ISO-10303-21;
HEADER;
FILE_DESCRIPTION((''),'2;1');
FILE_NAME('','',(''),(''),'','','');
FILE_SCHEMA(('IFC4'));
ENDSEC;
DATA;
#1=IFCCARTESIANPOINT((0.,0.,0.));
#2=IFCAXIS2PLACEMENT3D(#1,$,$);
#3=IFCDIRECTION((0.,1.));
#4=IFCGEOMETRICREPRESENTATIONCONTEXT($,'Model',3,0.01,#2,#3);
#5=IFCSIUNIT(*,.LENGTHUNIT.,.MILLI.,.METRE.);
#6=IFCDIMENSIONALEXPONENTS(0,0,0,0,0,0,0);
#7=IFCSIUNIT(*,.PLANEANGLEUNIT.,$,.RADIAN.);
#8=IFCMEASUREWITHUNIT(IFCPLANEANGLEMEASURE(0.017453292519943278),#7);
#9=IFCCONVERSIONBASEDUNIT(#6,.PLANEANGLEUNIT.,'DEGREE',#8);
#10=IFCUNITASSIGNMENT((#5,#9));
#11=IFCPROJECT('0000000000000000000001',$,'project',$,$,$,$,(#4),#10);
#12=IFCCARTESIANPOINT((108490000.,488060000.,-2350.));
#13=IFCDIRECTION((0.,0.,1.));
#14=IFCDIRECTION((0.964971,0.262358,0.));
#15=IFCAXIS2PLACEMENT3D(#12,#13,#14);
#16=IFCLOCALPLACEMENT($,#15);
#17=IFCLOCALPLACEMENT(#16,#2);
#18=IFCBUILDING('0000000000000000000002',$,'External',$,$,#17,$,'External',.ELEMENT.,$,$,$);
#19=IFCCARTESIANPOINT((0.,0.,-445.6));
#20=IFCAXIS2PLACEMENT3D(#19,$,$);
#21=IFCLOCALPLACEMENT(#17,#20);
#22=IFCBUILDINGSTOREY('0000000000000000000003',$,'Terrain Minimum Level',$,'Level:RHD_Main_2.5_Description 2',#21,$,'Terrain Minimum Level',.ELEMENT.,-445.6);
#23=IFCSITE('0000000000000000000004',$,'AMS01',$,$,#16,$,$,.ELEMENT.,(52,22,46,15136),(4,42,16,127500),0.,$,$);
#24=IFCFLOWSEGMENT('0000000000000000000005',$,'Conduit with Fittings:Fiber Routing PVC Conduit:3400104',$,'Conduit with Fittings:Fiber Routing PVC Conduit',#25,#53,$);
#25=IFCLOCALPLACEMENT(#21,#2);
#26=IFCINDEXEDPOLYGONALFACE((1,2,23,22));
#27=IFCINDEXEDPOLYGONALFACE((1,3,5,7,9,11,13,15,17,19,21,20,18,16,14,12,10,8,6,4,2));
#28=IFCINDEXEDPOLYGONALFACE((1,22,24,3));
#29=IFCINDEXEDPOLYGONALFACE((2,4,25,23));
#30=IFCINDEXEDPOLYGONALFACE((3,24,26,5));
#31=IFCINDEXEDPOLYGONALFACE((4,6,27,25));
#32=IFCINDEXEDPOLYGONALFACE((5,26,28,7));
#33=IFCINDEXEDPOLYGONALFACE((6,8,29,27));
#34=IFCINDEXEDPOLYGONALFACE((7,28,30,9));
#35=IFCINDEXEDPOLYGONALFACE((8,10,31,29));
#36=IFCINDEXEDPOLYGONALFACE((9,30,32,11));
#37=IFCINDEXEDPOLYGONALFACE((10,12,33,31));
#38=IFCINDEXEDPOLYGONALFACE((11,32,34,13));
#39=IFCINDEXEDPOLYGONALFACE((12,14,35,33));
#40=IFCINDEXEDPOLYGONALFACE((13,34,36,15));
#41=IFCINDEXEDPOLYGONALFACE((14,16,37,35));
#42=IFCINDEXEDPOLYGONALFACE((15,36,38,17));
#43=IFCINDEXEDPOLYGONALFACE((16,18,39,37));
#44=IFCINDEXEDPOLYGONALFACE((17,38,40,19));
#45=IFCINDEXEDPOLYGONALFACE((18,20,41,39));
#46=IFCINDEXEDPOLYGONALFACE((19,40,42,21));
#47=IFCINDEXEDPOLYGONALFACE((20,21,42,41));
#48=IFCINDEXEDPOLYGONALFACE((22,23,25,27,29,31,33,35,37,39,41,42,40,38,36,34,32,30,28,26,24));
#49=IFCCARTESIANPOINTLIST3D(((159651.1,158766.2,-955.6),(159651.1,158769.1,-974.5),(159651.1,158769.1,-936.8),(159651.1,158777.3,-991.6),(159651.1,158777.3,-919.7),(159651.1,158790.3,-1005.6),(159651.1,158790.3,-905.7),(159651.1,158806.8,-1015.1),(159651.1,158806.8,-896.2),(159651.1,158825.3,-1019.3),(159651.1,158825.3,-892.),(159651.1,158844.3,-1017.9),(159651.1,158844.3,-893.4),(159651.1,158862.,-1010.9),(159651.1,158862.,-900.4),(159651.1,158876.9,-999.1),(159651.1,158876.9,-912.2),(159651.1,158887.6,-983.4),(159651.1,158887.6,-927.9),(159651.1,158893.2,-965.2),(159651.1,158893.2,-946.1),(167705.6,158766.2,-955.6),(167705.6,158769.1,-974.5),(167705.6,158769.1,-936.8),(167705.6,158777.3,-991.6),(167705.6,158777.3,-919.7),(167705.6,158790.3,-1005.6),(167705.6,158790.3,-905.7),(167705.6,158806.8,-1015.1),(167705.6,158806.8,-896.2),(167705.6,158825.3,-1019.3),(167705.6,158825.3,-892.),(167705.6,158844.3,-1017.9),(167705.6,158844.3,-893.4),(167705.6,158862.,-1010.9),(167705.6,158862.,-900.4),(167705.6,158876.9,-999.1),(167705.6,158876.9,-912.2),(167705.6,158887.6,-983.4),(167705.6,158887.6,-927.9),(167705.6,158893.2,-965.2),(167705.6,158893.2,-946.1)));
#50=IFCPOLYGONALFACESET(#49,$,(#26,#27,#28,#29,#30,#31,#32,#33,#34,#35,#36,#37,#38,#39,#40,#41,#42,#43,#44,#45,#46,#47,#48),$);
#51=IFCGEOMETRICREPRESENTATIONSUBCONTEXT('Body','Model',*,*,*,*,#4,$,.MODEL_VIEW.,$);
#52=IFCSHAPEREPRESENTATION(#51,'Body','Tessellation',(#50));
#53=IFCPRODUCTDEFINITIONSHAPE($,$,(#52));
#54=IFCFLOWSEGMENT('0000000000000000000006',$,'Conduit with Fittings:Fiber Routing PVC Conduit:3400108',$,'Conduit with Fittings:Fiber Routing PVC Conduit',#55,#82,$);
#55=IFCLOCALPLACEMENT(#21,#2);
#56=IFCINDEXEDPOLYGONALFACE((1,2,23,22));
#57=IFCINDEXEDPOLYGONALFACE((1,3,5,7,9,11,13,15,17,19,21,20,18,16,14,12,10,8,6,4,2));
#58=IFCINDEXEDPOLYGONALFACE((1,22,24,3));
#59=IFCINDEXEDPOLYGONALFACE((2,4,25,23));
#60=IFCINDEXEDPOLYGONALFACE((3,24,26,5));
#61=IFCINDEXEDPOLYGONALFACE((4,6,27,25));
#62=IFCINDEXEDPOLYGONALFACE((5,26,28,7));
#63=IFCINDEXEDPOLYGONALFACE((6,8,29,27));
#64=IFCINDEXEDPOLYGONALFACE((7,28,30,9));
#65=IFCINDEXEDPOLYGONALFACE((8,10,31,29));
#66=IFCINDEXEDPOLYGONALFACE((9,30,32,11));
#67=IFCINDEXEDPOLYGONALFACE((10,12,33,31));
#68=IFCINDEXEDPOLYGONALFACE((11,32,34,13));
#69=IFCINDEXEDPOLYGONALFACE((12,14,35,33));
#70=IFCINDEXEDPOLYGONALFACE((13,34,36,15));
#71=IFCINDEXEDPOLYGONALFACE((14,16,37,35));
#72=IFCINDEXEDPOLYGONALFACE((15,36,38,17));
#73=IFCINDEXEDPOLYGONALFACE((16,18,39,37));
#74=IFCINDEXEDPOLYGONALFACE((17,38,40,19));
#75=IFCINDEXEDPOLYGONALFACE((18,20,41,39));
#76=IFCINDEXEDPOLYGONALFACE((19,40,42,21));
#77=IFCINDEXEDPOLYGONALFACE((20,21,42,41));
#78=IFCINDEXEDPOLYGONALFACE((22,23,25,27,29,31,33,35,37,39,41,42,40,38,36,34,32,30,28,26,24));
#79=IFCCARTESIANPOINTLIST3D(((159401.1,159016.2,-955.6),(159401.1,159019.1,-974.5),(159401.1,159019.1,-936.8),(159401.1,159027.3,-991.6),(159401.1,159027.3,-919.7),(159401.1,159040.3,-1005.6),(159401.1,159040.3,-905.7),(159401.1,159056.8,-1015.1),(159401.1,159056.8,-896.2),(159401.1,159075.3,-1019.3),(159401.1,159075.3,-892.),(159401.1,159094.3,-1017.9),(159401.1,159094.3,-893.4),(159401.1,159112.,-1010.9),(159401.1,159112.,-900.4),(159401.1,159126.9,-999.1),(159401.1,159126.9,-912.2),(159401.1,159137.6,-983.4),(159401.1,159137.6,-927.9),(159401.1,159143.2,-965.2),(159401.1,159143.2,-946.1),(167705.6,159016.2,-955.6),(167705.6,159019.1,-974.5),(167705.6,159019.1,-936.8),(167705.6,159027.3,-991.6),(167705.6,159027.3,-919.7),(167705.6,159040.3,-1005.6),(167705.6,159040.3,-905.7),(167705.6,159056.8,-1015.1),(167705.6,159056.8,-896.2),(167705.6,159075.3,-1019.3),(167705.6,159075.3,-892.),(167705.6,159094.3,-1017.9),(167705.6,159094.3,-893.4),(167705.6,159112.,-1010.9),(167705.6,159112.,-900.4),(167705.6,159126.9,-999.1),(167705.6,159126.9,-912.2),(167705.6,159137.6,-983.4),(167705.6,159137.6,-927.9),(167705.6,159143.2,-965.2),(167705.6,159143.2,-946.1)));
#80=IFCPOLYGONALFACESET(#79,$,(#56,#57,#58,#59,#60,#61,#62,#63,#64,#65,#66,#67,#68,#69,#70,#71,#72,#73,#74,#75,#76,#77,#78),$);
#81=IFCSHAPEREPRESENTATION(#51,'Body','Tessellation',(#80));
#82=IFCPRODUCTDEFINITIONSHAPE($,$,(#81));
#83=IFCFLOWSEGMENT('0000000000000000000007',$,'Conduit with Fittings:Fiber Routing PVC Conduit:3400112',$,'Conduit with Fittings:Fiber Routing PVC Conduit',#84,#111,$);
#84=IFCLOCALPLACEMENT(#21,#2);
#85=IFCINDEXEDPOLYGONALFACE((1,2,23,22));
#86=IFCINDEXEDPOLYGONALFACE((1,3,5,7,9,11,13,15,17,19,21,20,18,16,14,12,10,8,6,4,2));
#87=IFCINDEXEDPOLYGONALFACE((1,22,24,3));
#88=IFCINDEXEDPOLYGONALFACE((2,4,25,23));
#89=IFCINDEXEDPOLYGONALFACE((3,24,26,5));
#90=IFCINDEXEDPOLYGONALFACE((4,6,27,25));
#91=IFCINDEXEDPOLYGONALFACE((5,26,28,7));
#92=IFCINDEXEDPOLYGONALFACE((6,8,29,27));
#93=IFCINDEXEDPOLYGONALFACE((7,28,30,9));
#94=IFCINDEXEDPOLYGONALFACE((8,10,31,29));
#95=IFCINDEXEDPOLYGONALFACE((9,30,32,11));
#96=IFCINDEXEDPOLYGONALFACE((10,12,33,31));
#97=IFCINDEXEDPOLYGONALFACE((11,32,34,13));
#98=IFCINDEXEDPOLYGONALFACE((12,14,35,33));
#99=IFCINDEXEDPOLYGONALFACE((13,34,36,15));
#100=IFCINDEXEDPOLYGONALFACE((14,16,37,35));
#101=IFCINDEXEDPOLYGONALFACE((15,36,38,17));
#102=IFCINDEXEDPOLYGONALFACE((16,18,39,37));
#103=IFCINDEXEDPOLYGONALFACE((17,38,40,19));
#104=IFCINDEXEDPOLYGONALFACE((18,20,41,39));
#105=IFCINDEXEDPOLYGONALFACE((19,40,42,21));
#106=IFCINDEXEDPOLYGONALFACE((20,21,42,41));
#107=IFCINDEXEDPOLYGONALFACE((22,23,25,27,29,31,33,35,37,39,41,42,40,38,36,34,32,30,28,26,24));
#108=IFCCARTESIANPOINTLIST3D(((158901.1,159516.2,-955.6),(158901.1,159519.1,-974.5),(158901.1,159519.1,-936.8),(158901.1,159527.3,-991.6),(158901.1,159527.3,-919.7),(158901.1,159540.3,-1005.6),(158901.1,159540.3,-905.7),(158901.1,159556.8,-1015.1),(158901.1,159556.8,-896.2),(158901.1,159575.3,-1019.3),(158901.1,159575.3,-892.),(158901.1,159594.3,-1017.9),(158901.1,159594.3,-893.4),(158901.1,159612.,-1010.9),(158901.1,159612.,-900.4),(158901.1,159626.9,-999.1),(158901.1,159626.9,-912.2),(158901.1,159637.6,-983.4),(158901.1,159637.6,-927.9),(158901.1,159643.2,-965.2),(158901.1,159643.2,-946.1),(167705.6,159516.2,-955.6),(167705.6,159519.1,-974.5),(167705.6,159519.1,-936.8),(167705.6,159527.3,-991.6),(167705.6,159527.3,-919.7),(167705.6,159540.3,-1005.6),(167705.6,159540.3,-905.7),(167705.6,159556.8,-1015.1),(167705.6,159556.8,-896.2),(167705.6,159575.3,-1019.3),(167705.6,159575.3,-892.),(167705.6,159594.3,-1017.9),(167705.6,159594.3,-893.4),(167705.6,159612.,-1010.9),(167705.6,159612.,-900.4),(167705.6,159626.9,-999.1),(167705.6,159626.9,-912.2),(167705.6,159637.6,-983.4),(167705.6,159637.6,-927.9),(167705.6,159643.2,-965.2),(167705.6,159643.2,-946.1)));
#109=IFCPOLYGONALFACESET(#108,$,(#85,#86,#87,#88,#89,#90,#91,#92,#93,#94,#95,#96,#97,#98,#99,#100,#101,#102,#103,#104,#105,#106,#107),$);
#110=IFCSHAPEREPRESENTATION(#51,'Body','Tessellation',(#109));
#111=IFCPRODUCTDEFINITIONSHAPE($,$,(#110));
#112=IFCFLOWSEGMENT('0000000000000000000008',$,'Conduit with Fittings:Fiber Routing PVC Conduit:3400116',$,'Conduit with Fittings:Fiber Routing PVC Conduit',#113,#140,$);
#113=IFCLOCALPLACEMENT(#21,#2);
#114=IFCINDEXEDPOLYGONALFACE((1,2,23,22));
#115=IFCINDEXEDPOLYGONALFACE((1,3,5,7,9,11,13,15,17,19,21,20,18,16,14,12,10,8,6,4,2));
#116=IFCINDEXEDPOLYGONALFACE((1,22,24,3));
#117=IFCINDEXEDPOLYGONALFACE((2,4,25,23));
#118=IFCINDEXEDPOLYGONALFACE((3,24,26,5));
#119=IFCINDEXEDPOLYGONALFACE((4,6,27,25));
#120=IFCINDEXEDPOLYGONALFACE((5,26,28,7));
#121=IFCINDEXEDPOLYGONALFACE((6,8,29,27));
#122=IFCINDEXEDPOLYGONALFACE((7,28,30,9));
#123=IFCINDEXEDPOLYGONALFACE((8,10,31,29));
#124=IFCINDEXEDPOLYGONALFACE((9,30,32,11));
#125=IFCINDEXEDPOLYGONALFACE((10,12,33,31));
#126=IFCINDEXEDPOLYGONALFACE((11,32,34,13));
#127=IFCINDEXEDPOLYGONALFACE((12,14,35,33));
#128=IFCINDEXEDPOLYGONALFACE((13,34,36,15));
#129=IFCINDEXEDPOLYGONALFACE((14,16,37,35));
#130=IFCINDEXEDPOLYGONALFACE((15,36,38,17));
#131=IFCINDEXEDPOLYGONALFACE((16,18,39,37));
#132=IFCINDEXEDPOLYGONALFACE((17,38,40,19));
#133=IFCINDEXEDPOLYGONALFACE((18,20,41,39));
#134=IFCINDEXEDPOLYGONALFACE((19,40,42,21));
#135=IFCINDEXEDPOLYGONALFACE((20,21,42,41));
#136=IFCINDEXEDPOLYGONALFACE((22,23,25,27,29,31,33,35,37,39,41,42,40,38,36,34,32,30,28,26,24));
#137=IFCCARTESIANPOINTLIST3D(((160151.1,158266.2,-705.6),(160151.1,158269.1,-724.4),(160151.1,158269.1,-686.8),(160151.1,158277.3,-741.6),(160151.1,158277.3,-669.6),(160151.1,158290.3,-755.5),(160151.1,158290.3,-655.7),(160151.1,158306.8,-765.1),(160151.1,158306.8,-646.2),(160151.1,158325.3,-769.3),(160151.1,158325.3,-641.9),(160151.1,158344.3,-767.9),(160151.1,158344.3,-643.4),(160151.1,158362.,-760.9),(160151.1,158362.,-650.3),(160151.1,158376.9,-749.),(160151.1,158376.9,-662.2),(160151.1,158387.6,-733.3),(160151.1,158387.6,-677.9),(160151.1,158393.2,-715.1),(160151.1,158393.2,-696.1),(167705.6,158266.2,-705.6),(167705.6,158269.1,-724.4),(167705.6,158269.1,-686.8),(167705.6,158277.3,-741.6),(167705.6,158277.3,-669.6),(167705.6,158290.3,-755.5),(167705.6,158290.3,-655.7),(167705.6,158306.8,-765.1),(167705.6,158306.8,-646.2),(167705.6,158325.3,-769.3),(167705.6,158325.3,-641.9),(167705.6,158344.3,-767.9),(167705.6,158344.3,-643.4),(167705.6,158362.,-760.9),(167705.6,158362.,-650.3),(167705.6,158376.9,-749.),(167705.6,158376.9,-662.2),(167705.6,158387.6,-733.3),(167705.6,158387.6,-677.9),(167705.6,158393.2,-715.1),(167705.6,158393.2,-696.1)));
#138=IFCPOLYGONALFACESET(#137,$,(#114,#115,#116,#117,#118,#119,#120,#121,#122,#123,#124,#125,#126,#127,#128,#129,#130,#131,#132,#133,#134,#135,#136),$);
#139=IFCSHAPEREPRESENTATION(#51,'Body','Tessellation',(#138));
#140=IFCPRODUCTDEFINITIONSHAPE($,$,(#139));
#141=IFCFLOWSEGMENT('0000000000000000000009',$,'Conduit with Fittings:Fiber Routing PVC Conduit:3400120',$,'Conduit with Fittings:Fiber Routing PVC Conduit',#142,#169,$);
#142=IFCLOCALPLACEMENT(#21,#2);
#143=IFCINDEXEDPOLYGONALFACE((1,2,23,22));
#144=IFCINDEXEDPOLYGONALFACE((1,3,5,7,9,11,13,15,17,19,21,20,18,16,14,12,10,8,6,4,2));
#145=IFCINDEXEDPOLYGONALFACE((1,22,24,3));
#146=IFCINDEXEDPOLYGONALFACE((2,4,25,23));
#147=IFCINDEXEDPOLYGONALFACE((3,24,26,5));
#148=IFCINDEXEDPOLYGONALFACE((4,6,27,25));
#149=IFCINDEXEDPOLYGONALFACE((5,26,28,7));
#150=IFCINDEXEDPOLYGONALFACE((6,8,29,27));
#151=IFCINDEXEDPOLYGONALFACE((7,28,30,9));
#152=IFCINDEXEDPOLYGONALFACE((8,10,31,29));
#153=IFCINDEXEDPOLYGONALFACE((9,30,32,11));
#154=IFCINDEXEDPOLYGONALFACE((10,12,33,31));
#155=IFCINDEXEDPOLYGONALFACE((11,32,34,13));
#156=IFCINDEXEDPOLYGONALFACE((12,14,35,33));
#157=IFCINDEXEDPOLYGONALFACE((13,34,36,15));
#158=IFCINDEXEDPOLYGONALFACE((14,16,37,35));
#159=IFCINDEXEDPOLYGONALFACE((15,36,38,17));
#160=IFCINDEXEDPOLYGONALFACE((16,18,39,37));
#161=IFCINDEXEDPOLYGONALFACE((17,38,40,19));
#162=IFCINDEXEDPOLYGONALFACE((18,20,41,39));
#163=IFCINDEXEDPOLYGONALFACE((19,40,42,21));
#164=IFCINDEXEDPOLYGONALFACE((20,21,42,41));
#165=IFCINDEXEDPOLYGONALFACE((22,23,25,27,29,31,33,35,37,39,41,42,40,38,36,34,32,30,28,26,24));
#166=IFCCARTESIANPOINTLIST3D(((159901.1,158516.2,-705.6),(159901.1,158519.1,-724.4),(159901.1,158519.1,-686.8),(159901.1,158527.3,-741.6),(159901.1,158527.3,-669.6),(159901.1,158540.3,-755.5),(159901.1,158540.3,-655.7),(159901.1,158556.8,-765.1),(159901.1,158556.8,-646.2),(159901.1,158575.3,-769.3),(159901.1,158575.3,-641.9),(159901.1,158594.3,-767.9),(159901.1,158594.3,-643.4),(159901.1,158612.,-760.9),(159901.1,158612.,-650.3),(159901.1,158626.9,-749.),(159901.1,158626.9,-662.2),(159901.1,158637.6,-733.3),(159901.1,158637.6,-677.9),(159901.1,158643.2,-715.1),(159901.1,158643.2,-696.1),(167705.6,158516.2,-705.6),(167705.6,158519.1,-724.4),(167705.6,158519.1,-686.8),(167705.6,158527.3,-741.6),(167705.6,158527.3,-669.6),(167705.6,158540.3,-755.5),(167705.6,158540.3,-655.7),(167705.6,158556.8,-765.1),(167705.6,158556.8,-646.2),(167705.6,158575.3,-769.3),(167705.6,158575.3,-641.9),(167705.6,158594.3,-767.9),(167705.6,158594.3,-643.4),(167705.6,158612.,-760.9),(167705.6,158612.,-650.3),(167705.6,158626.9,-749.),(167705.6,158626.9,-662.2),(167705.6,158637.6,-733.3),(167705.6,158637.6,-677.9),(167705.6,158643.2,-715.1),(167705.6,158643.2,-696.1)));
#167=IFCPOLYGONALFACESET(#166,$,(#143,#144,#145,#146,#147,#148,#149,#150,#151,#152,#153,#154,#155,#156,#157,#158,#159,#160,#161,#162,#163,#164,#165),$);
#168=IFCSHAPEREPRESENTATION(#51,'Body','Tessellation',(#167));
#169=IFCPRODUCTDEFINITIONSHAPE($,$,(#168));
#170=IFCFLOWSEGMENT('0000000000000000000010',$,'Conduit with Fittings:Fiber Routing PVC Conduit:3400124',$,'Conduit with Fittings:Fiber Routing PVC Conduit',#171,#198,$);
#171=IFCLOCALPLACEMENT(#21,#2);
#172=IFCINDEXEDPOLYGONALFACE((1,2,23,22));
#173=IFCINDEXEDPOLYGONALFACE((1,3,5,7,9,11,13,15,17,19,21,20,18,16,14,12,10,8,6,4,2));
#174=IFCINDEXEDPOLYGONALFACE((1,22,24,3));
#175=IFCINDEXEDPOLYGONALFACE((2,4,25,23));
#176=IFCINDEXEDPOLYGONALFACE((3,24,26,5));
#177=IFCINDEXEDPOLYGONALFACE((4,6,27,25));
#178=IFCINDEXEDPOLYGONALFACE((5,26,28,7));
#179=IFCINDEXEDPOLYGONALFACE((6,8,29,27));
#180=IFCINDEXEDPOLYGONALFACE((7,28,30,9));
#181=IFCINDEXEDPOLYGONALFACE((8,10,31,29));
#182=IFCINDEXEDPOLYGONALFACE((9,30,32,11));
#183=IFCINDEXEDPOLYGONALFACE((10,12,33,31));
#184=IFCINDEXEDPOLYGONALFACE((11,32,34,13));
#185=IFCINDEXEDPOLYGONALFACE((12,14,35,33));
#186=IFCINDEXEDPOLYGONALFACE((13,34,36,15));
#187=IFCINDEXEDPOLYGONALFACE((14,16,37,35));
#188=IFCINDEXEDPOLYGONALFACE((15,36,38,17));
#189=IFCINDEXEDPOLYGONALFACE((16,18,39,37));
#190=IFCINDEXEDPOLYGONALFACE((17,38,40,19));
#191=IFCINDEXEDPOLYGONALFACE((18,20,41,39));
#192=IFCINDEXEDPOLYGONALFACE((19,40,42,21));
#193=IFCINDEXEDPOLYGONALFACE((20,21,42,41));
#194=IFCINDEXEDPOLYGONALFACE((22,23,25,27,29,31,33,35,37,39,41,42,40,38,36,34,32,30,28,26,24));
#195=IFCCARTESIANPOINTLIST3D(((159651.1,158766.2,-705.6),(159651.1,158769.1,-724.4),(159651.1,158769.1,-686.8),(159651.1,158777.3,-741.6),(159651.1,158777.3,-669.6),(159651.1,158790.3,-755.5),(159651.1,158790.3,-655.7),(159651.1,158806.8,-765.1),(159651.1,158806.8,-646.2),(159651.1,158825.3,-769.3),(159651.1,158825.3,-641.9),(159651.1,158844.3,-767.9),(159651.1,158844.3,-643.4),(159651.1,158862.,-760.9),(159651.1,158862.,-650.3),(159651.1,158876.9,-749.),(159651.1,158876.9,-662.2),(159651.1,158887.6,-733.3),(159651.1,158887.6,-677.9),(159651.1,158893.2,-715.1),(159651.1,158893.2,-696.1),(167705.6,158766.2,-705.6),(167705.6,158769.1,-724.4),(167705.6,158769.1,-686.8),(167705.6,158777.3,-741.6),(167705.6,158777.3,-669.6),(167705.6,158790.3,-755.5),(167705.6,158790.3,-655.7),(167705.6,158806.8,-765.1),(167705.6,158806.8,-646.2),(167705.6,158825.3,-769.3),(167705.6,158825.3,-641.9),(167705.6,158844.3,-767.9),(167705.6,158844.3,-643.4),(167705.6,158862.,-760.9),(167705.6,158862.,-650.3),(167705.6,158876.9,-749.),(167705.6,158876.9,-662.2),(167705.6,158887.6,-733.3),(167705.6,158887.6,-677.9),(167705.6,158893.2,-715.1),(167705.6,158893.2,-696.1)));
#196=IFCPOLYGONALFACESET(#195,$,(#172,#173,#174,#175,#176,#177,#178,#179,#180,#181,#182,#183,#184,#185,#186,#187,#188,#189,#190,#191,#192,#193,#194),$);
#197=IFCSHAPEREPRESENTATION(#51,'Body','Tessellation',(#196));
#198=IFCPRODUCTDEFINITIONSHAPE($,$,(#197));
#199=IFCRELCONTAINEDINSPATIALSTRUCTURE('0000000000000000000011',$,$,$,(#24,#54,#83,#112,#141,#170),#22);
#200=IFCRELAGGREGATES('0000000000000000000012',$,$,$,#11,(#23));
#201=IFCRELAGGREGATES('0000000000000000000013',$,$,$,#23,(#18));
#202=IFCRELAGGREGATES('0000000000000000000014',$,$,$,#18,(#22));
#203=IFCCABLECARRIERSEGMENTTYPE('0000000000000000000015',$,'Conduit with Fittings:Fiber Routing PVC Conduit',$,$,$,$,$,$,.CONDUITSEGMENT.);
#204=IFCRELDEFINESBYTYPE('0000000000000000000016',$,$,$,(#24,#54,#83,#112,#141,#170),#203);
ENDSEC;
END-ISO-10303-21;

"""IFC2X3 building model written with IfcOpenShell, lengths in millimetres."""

from ifc_helpers import new_model, entity, si_unit, converted_unit, direction, frame, frame_2d, origin, origin_2d_with_axis, place, context, subcontext, project, spatial, circle, extrude, type_object, element, save


model = new_model("IFC2X3")

# Units and contexts
model_context = context("Model", 3, precision=0.01, world=origin(), true_north=direction((0.0, 1.0)))
body_context = subcontext(model_context, "Body", "Model", "MODEL_VIEW")
ifc_project = project(units=[si_unit("LENGTHUNIT", "METRE", prefix="MILLI"), converted_unit("PLANEANGLEUNIT", "DEGREE", entity("IfcPlaneAngleMeasure", 0.017453292519943278), si_unit("PLANEANGLEUNIT", "RADIAN"), dimensions=[0, 0, 0, 0, 0, 0, 0])], contexts=[model_context])

# Site, building, storey
site_placement = place(None, frame((108490000.0, 488060000.0, -2350.0), z_axis=(0.0, 0.0, 1.0), x_axis=(0.964971, 0.262358, 0.0)))
site = spatial("IfcSite", under=ifc_project, at=site_placement, Name="AMS01", CompositionType="ELEMENT", RefLatitude=(52, 22, 46, 15136), RefLongitude=(4, 42, 16, 127500), RefElevation=0.0)
building_placement = place(site_placement, origin())
building = spatial("IfcBuilding", under=site, at=building_placement, Name="External", LongName="External", CompositionType="ELEMENT")
storey_placement = place(building_placement, frame((0.0, 0.0, -445.6)))
storey = spatial("IfcBuildingStorey", under=building, at=storey_placement, Name="Terrain Minimum Level", ObjectType="Level:RHD_Main_2.5_Description 2", LongName="Terrain Minimum Level", CompositionType="ELEMENT", Elevation=-445.6)

# Flow segments
cable_carrier_segment_type = type_object("IfcCableCarrierSegmentType", Name="Conduit with Fittings:Fiber Routing PVC Conduit", PredefinedType="CONDUITSEGMENT")
flow_segment_1_placement = place(storey_placement, origin())
element("IfcFlowSegment", 1, at=flow_segment_1_placement, inside=storey, type_object=cable_carrier_segment_type, Name="Conduit with Fittings:Fiber Routing PVC Conduit:3400104", ObjectType="Conduit with Fittings:Fiber Routing PVC Conduit", context=body_context, shape_type="SweptSolid", body=[
    extrude(circle(Radius=63.9, at=origin_2d_with_axis()), frame((159651.1, 158830.1, -955.6), z_axis=(1.0, 0.0, 0.0), x_axis=(0.0, -1.0, 0.0)), (0.0, 0.0, 1.0), 8054.6),
])
flow_segment_2_placement = place(storey_placement, origin())
element("IfcFlowSegment", 2, at=flow_segment_2_placement, inside=storey, type_object=cable_carrier_segment_type, Name="Conduit with Fittings:Fiber Routing PVC Conduit:3400108", ObjectType="Conduit with Fittings:Fiber Routing PVC Conduit", context=body_context, shape_type="SweptSolid", body=[
    extrude(circle(Radius=63.9, at=origin_2d_with_axis()), frame((159401.1, 159080.1, -955.6), z_axis=(1.0, 0.0, 0.0), x_axis=(0.0, -1.0, 0.0)), (0.0, 0.0, 1.0), 8304.6),
])
flow_segment_3_placement = place(storey_placement, origin())
element("IfcFlowSegment", 3, at=flow_segment_3_placement, inside=storey, type_object=cable_carrier_segment_type, Name="Conduit with Fittings:Fiber Routing PVC Conduit:3400112", ObjectType="Conduit with Fittings:Fiber Routing PVC Conduit", context=body_context, shape_type="SweptSolid", body=[
    extrude(circle(Radius=63.9, at=origin_2d_with_axis()), frame((158901.1, 159580.1, -955.6), z_axis=(1.0, 0.0, 0.0), x_axis=(0.0, -1.0, 0.0)), (0.0, 0.0, 1.0), 8804.6),
])
flow_segment_4_placement = place(storey_placement, origin())
element("IfcFlowSegment", 4, at=flow_segment_4_placement, inside=storey, type_object=cable_carrier_segment_type, Name="Conduit with Fittings:Fiber Routing PVC Conduit:3400116", ObjectType="Conduit with Fittings:Fiber Routing PVC Conduit", context=body_context, shape_type="SweptSolid", body=[
    extrude(circle(Radius=63.9, at=frame_2d((0.0, 0.0), x_axis=(1.0, 0.0))), frame((160151.1, 158330.1, -705.6), z_axis=(1.0, 0.0, 0.0), x_axis=(0.0, -1.0, 0.0)), (0.0, 0.0, 1.0), 7554.6),
])
flow_segment_5_placement = place(storey_placement, origin())
element("IfcFlowSegment", 5, at=flow_segment_5_placement, inside=storey, type_object=cable_carrier_segment_type, Name="Conduit with Fittings:Fiber Routing PVC Conduit:3400120", ObjectType="Conduit with Fittings:Fiber Routing PVC Conduit", context=body_context, shape_type="SweptSolid", body=[
    extrude(circle(Radius=63.9, at=frame_2d((0.0, 0.0), x_axis=(1.0, 0.0))), frame((159901.1, 158580.1, -705.6), z_axis=(1.0, 0.0, 0.0), x_axis=(0.0, -1.0, 0.0)), (0.0, 0.0, 1.0), 7804.6),
])
flow_segment_6_placement = place(storey_placement, origin())
element("IfcFlowSegment", 6, at=flow_segment_6_placement, inside=storey, type_object=cable_carrier_segment_type, Name="Conduit with Fittings:Fiber Routing PVC Conduit:3400124", ObjectType="Conduit with Fittings:Fiber Routing PVC Conduit", context=body_context, shape_type="SweptSolid", body=[
    extrude(circle(Radius=63.9, at=frame_2d((0.0, 0.0), x_axis=(1.0, 0.0))), frame((159651.1, 158830.1, -705.6), z_axis=(1.0, 0.0, 0.0), x_axis=(0.0, -1.0, 0.0)), (0.0, 0.0, 1.0), 8054.6),
])

save(model, "model.ifc")
